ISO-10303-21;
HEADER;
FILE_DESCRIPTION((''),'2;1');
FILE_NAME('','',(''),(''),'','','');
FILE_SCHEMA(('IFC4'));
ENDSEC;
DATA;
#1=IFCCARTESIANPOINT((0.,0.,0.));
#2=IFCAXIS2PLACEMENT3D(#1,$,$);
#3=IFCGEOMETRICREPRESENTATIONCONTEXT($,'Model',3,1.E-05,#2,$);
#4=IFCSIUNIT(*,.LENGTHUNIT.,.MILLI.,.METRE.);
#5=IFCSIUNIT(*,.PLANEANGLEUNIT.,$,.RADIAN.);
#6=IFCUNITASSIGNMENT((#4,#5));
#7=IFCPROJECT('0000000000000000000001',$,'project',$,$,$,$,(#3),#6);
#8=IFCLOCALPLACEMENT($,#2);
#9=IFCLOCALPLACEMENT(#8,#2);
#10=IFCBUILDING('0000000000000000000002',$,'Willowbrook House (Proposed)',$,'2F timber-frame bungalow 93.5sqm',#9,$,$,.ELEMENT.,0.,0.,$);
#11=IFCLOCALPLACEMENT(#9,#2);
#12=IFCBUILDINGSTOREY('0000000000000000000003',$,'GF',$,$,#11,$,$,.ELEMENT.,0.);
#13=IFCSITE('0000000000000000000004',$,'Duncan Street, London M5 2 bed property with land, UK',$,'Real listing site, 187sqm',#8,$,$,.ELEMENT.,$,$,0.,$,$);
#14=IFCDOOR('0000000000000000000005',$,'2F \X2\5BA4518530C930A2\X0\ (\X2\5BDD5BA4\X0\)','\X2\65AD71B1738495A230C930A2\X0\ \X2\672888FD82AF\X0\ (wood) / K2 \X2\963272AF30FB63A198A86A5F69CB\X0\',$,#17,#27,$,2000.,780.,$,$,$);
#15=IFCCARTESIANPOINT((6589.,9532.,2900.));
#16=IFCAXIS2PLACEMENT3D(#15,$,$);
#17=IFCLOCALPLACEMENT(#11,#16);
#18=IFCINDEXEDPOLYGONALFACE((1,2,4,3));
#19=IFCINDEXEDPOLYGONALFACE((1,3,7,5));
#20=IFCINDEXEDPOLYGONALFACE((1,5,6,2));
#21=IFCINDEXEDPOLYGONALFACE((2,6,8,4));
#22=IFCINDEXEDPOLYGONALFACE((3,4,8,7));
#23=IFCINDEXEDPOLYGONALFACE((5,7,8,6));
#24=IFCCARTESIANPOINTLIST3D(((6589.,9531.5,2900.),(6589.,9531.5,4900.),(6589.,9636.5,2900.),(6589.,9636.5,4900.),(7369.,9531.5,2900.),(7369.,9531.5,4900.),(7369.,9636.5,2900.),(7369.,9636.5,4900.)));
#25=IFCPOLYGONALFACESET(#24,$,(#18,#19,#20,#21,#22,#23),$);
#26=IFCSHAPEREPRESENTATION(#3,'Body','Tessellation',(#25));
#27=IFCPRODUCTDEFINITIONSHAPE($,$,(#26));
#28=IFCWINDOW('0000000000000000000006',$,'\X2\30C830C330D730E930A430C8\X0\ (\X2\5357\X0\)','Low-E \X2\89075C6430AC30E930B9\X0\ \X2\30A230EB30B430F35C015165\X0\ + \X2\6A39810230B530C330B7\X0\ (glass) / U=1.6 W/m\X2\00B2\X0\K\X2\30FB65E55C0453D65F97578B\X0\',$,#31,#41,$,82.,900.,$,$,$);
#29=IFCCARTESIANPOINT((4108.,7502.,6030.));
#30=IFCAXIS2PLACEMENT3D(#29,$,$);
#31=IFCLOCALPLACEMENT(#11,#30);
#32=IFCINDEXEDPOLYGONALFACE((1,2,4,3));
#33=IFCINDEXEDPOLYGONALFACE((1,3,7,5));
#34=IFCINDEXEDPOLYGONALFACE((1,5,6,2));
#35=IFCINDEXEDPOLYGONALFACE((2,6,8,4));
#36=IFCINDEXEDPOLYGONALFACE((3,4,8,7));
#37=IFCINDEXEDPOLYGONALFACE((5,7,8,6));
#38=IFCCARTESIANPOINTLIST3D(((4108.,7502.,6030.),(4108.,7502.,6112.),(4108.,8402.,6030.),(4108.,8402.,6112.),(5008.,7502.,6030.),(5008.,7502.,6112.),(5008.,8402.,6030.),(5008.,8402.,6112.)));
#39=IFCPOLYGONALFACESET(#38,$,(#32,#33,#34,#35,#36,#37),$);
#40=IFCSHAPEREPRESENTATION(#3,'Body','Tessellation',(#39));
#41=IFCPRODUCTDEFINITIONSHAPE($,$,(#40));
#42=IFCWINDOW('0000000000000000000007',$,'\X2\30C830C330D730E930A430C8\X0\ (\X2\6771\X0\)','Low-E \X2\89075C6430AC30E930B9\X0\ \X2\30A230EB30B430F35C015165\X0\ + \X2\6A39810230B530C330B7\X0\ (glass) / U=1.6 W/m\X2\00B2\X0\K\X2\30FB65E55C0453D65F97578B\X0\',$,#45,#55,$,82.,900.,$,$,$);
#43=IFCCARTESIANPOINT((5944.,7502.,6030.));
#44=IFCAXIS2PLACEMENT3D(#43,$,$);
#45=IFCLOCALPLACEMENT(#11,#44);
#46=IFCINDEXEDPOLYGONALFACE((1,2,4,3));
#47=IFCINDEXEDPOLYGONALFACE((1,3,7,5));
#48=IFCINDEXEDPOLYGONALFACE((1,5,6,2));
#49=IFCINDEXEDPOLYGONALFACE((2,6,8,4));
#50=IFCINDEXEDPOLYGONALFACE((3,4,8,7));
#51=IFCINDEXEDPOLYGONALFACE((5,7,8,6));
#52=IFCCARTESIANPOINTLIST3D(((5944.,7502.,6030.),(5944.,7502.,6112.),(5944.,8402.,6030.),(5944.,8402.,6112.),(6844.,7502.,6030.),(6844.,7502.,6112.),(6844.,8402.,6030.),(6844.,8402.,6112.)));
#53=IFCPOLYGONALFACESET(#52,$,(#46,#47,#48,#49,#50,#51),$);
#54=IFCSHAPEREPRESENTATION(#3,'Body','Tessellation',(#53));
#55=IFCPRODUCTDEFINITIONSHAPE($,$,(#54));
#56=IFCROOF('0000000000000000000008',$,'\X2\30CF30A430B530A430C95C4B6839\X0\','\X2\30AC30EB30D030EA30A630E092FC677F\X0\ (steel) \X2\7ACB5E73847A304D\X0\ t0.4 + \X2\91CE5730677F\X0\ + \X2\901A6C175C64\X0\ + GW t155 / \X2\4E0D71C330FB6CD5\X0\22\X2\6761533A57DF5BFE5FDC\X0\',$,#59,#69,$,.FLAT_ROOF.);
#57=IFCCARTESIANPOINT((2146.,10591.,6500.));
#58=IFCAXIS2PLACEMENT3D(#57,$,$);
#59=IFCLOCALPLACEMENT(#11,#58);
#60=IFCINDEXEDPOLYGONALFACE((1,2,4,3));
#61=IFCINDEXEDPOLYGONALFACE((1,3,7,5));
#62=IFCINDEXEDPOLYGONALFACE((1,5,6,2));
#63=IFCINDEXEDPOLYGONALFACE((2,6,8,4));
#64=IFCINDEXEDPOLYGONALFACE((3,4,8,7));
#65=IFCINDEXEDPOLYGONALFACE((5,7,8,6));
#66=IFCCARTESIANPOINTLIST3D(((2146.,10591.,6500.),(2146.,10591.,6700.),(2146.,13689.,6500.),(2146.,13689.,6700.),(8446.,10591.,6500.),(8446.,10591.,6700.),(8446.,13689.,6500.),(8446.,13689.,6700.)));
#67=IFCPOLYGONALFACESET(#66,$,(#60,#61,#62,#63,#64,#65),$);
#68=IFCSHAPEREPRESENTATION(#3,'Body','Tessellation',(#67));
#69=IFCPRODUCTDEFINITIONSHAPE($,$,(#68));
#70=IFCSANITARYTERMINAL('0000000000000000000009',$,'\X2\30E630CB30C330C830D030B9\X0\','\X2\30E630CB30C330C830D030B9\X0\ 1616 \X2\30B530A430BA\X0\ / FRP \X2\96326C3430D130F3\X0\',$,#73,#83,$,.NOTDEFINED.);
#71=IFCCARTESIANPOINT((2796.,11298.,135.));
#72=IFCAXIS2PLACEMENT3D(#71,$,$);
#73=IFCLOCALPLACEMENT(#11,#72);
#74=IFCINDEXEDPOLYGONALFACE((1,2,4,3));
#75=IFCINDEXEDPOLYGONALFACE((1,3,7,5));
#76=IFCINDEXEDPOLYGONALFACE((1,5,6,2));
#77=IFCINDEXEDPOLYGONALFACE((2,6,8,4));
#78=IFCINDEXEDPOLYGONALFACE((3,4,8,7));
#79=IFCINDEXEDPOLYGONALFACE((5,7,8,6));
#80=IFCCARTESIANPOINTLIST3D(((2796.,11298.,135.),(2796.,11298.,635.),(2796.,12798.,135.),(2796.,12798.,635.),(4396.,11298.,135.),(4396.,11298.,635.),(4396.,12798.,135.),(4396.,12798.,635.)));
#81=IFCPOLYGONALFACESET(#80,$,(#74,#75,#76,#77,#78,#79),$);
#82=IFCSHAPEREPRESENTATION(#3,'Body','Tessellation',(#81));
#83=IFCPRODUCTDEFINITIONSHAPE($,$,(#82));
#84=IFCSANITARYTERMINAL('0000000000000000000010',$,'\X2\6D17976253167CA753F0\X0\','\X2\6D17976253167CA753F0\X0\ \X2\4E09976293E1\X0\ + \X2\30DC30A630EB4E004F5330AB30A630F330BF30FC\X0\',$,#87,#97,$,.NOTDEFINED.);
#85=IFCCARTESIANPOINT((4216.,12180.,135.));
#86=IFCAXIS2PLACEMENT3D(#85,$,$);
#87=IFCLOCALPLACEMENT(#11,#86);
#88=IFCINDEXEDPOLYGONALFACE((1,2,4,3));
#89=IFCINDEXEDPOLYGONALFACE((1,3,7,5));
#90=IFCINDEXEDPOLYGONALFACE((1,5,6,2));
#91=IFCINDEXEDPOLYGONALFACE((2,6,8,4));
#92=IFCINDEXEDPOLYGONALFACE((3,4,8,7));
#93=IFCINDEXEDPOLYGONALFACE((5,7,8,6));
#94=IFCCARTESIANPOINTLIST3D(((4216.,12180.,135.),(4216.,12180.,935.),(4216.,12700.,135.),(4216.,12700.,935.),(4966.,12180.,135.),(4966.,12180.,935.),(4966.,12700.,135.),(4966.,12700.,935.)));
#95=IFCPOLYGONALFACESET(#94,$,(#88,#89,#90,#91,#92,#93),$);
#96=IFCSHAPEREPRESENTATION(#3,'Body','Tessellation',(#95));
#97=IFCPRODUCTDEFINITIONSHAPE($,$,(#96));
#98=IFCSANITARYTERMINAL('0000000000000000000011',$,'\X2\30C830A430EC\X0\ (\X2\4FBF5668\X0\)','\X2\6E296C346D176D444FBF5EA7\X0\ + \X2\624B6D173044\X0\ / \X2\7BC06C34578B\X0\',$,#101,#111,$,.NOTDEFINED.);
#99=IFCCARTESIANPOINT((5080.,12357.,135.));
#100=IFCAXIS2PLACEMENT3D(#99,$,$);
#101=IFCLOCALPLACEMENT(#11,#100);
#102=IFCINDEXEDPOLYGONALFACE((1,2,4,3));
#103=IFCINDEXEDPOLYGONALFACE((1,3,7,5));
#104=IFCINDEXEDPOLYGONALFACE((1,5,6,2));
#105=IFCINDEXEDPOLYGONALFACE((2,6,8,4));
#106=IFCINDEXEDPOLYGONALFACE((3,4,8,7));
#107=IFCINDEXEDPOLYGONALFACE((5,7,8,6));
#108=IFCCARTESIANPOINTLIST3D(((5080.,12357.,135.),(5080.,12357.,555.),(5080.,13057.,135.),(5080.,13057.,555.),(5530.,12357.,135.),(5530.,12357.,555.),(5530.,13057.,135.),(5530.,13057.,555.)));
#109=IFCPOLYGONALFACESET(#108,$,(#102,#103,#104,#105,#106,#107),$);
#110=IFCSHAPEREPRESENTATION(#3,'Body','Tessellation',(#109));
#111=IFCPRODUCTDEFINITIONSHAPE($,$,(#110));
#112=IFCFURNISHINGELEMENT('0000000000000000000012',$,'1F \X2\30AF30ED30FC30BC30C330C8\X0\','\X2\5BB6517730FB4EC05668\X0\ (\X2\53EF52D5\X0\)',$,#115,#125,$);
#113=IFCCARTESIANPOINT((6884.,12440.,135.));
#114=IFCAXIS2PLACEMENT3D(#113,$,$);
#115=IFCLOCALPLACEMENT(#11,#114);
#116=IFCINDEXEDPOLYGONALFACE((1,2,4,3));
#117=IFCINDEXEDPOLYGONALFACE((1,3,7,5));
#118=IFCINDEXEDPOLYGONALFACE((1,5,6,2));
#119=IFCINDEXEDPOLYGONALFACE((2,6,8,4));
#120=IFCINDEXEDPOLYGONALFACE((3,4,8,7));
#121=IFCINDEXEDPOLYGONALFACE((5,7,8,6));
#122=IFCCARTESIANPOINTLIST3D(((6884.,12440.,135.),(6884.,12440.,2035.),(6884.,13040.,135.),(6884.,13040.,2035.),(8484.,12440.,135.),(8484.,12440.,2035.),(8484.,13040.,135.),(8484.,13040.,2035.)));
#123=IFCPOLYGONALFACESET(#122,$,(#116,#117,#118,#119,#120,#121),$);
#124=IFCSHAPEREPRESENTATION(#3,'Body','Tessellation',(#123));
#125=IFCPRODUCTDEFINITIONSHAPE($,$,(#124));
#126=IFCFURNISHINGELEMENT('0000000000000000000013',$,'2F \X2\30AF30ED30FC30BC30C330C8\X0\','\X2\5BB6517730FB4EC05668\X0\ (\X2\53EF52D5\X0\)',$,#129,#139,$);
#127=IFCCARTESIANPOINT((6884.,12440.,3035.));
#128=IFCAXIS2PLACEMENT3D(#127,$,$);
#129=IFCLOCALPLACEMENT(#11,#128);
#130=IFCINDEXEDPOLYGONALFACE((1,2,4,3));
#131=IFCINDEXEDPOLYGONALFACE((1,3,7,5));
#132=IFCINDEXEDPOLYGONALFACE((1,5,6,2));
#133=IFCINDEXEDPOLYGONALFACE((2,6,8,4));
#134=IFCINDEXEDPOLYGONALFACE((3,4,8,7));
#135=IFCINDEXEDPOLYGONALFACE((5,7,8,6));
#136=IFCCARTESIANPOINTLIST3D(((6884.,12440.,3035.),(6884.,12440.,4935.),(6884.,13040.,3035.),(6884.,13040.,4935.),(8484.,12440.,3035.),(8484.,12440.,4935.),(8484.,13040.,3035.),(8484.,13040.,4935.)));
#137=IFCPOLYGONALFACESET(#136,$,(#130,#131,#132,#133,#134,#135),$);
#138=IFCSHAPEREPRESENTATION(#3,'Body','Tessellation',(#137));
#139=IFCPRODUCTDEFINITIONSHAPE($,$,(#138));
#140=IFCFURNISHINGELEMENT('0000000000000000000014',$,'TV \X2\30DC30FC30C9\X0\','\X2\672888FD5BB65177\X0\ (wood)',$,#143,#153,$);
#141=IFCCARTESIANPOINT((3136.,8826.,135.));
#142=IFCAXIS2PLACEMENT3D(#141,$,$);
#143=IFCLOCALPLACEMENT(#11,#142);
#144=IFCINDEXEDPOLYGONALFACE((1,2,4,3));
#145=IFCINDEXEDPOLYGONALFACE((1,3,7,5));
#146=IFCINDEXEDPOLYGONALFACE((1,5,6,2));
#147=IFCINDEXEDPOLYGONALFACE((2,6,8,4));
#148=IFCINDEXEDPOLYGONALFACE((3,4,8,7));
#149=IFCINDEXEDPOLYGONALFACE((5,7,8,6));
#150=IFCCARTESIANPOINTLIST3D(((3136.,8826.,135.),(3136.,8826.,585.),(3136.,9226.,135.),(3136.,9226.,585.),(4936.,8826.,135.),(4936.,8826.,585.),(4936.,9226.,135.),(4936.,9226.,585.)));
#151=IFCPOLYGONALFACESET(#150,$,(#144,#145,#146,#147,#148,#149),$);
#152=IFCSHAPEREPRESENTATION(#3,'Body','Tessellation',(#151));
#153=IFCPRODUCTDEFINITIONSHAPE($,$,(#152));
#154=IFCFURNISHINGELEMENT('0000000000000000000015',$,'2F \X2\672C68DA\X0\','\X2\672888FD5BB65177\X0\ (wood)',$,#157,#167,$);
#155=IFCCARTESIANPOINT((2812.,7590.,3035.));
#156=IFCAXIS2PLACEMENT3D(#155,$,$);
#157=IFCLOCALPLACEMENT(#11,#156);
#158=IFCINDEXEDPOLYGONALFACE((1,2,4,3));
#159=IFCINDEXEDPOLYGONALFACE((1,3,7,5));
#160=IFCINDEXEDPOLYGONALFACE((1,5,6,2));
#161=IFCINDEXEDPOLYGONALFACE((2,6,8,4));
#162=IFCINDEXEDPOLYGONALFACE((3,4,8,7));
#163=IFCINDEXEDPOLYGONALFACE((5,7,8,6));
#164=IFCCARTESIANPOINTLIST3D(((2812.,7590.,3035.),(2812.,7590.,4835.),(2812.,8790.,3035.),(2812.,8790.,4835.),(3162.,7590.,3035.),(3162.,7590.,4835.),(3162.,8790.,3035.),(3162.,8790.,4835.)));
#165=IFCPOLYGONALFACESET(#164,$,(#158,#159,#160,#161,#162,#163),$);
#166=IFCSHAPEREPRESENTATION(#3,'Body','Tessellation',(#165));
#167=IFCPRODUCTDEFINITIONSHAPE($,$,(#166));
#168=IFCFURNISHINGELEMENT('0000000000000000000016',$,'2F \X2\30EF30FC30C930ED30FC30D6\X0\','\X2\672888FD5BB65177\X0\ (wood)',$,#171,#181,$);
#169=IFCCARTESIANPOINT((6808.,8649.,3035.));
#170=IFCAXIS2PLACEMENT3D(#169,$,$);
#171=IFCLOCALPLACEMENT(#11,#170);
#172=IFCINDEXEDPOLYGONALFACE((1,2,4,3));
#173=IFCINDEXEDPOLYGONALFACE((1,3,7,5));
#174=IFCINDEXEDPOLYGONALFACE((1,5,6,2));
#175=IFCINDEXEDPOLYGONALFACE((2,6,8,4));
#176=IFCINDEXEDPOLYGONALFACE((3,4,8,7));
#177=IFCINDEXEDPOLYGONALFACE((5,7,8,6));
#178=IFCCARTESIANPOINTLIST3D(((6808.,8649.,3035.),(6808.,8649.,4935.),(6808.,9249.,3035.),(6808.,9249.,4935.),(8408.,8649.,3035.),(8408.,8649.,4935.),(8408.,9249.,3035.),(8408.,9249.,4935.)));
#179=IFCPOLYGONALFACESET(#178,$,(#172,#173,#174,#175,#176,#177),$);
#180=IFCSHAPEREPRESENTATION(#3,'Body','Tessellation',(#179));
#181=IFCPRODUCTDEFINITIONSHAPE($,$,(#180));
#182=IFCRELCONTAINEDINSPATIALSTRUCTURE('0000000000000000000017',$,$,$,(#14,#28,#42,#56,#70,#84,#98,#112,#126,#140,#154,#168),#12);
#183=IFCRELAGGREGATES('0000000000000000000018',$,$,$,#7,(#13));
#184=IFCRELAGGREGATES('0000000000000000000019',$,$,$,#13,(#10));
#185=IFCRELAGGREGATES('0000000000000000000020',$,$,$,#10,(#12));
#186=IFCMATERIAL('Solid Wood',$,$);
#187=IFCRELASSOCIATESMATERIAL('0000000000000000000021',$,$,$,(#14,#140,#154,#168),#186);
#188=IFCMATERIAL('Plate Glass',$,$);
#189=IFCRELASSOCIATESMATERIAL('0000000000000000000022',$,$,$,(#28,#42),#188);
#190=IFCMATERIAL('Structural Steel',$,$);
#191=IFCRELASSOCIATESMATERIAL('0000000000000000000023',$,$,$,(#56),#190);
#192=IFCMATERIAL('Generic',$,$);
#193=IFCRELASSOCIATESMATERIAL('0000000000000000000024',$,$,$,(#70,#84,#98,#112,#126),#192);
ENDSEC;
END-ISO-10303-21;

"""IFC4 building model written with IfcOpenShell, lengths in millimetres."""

from ifc_helpers import new_model, si_unit, frame, frame_2d, origin, place, context, project, spatial, rectangle, extrude, material, element, save


model = new_model("IFC4")

# Units and contexts
model_context = context("Model", 3, precision=1e-05, world=origin())
ifc_project = project(units=[si_unit("LENGTHUNIT", "METRE", prefix="MILLI"), si_unit("PLANEANGLEUNIT", "RADIAN")], contexts=[model_context])

# Site, building, storey
site_placement = place(None, origin())
site = spatial("IfcSite", under=ifc_project, at=site_placement, Name="Duncan Street, London M5 2 bed property with land, UK", ObjectType="Real listing site, 187sqm", CompositionType="ELEMENT", RefElevation=0.0)
building_placement = place(site_placement, origin())
building = spatial("IfcBuilding", under=site, at=building_placement, Name="Willowbrook House (Proposed)", ObjectType="2F timber-frame bungalow 93.5sqm", CompositionType="ELEMENT", ElevationOfRefHeight=0.0, ElevationOfTerrain=0.0)
storey_placement = place(building_placement, origin())
storey = spatial("IfcBuildingStorey", under=building, at=storey_placement, Name="GF", CompositionType="ELEMENT", Elevation=0.0)

# Shared definitions
ifc_material_1 = material(Name="Solid Wood")
ifc_material_2 = material(Name="Plate Glass")

# Door
door_1_placement = place(storey_placement, frame((6589.0, 9532.0, 2900.0)))
element("IfcDoor", 1, at=door_1_placement, inside=storey, material=ifc_material_1, Name="2F 室内ドア (寝室)", Description="断熱玄関ドア 木製芯 (wood) / K2 防犯・採風機構", OverallHeight=2000.0, OverallWidth=780.0, context=model_context, shape_type="SweptSolid", body=[
    extrude(rectangle(XDim=780.0, YDim=105.0, at=frame_2d((390.0, 52.0))), frame((6589.0, 9532.0, 2900.0)), (0.0, 0.0, 1.0), 2000.0),
])

# Windows
window_1_placement = place(storey_placement, frame((4108.0, 7502.0, 6030.0)))
element("IfcWindow", 2, at=window_1_placement, inside=storey, material=ifc_material_2, Name="トップライト (南)", Description="Low-E 複層ガラス アルゴン封入 + 樹脂サッシ (glass) / U=1.6 W/m²K・日射取得型", OverallHeight=82.0, OverallWidth=900.0, context=model_context, shape_type="SweptSolid", body=[
    extrude(rectangle(XDim=900.0, YDim=900.0, at=frame_2d((450.0, 450.0))), frame((4108.0, 7502.0, 6030.0)), (0.0, 0.0, 1.0), 82.0),
])
window_2_placement = place(storey_placement, frame((5944.0, 7502.0, 6030.0)))
element("IfcWindow", 3, at=window_2_placement, inside=storey, material=ifc_material_2, Name="トップライト (東)", Description="Low-E 複層ガラス アルゴン封入 + 樹脂サッシ (glass) / U=1.6 W/m²K・日射取得型", OverallHeight=82.0, OverallWidth=900.0, context=model_context, shape_type="SweptSolid", body=[
    extrude(rectangle(XDim=900.0, YDim=900.0, at=frame_2d((450.0, 450.0))), frame((5944.0, 7502.0, 6030.0)), (0.0, 0.0, 1.0), 82.0),
])

# Roof
ifc_material_3 = material(Name="Structural Steel")
roof_placement = place(storey_placement, frame((2146.0, 10591.0, 6500.0)))
element("IfcRoof", 4, at=roof_placement, inside=storey, material=ifc_material_3, Name="ハイサイド屋根", Description="ガルバリウム鋼板 (steel) 立平葺き t0.4 + 野地板 + 通気層 + GW t155 / 不燃・法22条区域対応", PredefinedType="FLAT_ROOF", context=model_context, shape_type="SweptSolid", body=[
    extrude(rectangle(XDim=6300.0, YDim=3098.0, at=frame_2d((3150.0, 1549.0))), frame((2146.0, 10591.0, 6500.0)), (0.0, 0.0, 1.0), 200.0),
])

# Sanitary terminals
ifc_material_4 = material(Name="Generic")
sanitary_terminal_1_placement = place(storey_placement, frame((2796.0, 11298.0, 135.0)))
element("IfcSanitaryTerminal", 5, at=sanitary_terminal_1_placement, inside=storey, material=ifc_material_4, Name="ユニットバス", Description="ユニットバス 1616 サイズ / FRP 防水パン", PredefinedType="NOTDEFINED", context=model_context, shape_type="SweptSolid", body=[
    extrude(rectangle(XDim=1600.0, YDim=1500.0, at=frame_2d((800.0, 750.0))), frame((2796.0, 11298.0, 135.0)), (0.0, 0.0, 1.0), 500.0),
])
sanitary_terminal_2_placement = place(storey_placement, frame((4216.0, 12180.0, 135.0)))
element("IfcSanitaryTerminal", 6, at=sanitary_terminal_2_placement, inside=storey, material=ifc_material_4, Name="洗面化粧台", Description="洗面化粧台 三面鏡 + ボウル一体カウンター", PredefinedType="NOTDEFINED", context=model_context, shape_type="SweptSolid", body=[
    extrude(rectangle(XDim=750.0, YDim=520.0, at=frame_2d((375.0, 260.0))), frame((4216.0, 12180.0, 135.0)), (0.0, 0.0, 1.0), 800.0),
])
sanitary_terminal_3_placement = place(storey_placement, frame((5080.0, 12357.0, 135.0)))
element("IfcSanitaryTerminal", 7, at=sanitary_terminal_3_placement, inside=storey, material=ifc_material_4, Name="トイレ (便器)", Description="温水洗浄便座 + 手洗い / 節水型", PredefinedType="NOTDEFINED", context=model_context, shape_type="SweptSolid", body=[
    extrude(rectangle(XDim=450.0, YDim=700.0, at=frame_2d((225.0, 350.0))), frame((5080.0, 12357.0, 135.0)), (0.0, 0.0, 1.0), 420.0),
])

# Furnishing elements
furnishing_1_placement = place(storey_placement, frame((6884.0, 12440.0, 135.0)))
element("IfcFurnishingElement", 8, at=furnishing_1_placement, inside=storey, material=ifc_material_4, Name="1F クローゼット", Description="家具・什器 (可動)", context=model_context, shape_type="SweptSolid", body=[
    extrude(rectangle(XDim=1600.0, YDim=600.0, at=frame_2d((800.0, 300.0))), frame((6884.0, 12440.0, 135.0)), (0.0, 0.0, 1.0), 1900.0),
])
furnishing_2_placement = place(storey_placement, frame((6884.0, 12440.0, 3035.0)))
element("IfcFurnishingElement", 9, at=furnishing_2_placement, inside=storey, material=ifc_material_4, Name="2F クローゼット", Description="家具・什器 (可動)", context=model_context, shape_type="SweptSolid", body=[
    extrude(rectangle(XDim=1600.0, YDim=600.0, at=frame_2d((800.0, 300.0))), frame((6884.0, 12440.0, 3035.0)), (0.0, 0.0, 1.0), 1900.0),
])
furnishing_3_placement = place(storey_placement, frame((3136.0, 8826.0, 135.0)))
element("IfcFurnishingElement", 10, at=furnishing_3_placement, inside=storey, material=ifc_material_1, Name="TV ボード", Description="木製家具 (wood)", context=model_context, shape_type="SweptSolid", body=[
    extrude(rectangle(XDim=1800.0, YDim=400.0, at=frame_2d((900.0, 200.0))), frame((3136.0, 8826.0, 135.0)), (0.0, 0.0, 1.0), 450.0),
])
furnishing_4_placement = place(storey_placement, frame((2812.0, 7590.0, 3035.0)))
element("IfcFurnishingElement", 11, at=furnishing_4_placement, inside=storey, material=ifc_material_1, Name="2F 本棚", Description="木製家具 (wood)", context=model_context, shape_type="SweptSolid", body=[
    extrude(rectangle(XDim=350.0, YDim=1200.0, at=frame_2d((175.0, 600.0))), frame((2812.0, 7590.0, 3035.0)), (0.0, 0.0, 1.0), 1800.0),
])
furnishing_5_placement = place(storey_placement, frame((6808.0, 8649.0, 3035.0)))
element("IfcFurnishingElement", 12, at=furnishing_5_placement, inside=storey, material=ifc_material_1, Name="2F ワードローブ", Description="木製家具 (wood)", context=model_context, shape_type="SweptSolid", body=[
    extrude(rectangle(XDim=1600.0, YDim=600.0, at=frame_2d((800.0, 300.0))), frame((6808.0, 8649.0, 3035.0)), (0.0, 0.0, 1.0), 1900.0),
])

save(model, "model.ifc")
